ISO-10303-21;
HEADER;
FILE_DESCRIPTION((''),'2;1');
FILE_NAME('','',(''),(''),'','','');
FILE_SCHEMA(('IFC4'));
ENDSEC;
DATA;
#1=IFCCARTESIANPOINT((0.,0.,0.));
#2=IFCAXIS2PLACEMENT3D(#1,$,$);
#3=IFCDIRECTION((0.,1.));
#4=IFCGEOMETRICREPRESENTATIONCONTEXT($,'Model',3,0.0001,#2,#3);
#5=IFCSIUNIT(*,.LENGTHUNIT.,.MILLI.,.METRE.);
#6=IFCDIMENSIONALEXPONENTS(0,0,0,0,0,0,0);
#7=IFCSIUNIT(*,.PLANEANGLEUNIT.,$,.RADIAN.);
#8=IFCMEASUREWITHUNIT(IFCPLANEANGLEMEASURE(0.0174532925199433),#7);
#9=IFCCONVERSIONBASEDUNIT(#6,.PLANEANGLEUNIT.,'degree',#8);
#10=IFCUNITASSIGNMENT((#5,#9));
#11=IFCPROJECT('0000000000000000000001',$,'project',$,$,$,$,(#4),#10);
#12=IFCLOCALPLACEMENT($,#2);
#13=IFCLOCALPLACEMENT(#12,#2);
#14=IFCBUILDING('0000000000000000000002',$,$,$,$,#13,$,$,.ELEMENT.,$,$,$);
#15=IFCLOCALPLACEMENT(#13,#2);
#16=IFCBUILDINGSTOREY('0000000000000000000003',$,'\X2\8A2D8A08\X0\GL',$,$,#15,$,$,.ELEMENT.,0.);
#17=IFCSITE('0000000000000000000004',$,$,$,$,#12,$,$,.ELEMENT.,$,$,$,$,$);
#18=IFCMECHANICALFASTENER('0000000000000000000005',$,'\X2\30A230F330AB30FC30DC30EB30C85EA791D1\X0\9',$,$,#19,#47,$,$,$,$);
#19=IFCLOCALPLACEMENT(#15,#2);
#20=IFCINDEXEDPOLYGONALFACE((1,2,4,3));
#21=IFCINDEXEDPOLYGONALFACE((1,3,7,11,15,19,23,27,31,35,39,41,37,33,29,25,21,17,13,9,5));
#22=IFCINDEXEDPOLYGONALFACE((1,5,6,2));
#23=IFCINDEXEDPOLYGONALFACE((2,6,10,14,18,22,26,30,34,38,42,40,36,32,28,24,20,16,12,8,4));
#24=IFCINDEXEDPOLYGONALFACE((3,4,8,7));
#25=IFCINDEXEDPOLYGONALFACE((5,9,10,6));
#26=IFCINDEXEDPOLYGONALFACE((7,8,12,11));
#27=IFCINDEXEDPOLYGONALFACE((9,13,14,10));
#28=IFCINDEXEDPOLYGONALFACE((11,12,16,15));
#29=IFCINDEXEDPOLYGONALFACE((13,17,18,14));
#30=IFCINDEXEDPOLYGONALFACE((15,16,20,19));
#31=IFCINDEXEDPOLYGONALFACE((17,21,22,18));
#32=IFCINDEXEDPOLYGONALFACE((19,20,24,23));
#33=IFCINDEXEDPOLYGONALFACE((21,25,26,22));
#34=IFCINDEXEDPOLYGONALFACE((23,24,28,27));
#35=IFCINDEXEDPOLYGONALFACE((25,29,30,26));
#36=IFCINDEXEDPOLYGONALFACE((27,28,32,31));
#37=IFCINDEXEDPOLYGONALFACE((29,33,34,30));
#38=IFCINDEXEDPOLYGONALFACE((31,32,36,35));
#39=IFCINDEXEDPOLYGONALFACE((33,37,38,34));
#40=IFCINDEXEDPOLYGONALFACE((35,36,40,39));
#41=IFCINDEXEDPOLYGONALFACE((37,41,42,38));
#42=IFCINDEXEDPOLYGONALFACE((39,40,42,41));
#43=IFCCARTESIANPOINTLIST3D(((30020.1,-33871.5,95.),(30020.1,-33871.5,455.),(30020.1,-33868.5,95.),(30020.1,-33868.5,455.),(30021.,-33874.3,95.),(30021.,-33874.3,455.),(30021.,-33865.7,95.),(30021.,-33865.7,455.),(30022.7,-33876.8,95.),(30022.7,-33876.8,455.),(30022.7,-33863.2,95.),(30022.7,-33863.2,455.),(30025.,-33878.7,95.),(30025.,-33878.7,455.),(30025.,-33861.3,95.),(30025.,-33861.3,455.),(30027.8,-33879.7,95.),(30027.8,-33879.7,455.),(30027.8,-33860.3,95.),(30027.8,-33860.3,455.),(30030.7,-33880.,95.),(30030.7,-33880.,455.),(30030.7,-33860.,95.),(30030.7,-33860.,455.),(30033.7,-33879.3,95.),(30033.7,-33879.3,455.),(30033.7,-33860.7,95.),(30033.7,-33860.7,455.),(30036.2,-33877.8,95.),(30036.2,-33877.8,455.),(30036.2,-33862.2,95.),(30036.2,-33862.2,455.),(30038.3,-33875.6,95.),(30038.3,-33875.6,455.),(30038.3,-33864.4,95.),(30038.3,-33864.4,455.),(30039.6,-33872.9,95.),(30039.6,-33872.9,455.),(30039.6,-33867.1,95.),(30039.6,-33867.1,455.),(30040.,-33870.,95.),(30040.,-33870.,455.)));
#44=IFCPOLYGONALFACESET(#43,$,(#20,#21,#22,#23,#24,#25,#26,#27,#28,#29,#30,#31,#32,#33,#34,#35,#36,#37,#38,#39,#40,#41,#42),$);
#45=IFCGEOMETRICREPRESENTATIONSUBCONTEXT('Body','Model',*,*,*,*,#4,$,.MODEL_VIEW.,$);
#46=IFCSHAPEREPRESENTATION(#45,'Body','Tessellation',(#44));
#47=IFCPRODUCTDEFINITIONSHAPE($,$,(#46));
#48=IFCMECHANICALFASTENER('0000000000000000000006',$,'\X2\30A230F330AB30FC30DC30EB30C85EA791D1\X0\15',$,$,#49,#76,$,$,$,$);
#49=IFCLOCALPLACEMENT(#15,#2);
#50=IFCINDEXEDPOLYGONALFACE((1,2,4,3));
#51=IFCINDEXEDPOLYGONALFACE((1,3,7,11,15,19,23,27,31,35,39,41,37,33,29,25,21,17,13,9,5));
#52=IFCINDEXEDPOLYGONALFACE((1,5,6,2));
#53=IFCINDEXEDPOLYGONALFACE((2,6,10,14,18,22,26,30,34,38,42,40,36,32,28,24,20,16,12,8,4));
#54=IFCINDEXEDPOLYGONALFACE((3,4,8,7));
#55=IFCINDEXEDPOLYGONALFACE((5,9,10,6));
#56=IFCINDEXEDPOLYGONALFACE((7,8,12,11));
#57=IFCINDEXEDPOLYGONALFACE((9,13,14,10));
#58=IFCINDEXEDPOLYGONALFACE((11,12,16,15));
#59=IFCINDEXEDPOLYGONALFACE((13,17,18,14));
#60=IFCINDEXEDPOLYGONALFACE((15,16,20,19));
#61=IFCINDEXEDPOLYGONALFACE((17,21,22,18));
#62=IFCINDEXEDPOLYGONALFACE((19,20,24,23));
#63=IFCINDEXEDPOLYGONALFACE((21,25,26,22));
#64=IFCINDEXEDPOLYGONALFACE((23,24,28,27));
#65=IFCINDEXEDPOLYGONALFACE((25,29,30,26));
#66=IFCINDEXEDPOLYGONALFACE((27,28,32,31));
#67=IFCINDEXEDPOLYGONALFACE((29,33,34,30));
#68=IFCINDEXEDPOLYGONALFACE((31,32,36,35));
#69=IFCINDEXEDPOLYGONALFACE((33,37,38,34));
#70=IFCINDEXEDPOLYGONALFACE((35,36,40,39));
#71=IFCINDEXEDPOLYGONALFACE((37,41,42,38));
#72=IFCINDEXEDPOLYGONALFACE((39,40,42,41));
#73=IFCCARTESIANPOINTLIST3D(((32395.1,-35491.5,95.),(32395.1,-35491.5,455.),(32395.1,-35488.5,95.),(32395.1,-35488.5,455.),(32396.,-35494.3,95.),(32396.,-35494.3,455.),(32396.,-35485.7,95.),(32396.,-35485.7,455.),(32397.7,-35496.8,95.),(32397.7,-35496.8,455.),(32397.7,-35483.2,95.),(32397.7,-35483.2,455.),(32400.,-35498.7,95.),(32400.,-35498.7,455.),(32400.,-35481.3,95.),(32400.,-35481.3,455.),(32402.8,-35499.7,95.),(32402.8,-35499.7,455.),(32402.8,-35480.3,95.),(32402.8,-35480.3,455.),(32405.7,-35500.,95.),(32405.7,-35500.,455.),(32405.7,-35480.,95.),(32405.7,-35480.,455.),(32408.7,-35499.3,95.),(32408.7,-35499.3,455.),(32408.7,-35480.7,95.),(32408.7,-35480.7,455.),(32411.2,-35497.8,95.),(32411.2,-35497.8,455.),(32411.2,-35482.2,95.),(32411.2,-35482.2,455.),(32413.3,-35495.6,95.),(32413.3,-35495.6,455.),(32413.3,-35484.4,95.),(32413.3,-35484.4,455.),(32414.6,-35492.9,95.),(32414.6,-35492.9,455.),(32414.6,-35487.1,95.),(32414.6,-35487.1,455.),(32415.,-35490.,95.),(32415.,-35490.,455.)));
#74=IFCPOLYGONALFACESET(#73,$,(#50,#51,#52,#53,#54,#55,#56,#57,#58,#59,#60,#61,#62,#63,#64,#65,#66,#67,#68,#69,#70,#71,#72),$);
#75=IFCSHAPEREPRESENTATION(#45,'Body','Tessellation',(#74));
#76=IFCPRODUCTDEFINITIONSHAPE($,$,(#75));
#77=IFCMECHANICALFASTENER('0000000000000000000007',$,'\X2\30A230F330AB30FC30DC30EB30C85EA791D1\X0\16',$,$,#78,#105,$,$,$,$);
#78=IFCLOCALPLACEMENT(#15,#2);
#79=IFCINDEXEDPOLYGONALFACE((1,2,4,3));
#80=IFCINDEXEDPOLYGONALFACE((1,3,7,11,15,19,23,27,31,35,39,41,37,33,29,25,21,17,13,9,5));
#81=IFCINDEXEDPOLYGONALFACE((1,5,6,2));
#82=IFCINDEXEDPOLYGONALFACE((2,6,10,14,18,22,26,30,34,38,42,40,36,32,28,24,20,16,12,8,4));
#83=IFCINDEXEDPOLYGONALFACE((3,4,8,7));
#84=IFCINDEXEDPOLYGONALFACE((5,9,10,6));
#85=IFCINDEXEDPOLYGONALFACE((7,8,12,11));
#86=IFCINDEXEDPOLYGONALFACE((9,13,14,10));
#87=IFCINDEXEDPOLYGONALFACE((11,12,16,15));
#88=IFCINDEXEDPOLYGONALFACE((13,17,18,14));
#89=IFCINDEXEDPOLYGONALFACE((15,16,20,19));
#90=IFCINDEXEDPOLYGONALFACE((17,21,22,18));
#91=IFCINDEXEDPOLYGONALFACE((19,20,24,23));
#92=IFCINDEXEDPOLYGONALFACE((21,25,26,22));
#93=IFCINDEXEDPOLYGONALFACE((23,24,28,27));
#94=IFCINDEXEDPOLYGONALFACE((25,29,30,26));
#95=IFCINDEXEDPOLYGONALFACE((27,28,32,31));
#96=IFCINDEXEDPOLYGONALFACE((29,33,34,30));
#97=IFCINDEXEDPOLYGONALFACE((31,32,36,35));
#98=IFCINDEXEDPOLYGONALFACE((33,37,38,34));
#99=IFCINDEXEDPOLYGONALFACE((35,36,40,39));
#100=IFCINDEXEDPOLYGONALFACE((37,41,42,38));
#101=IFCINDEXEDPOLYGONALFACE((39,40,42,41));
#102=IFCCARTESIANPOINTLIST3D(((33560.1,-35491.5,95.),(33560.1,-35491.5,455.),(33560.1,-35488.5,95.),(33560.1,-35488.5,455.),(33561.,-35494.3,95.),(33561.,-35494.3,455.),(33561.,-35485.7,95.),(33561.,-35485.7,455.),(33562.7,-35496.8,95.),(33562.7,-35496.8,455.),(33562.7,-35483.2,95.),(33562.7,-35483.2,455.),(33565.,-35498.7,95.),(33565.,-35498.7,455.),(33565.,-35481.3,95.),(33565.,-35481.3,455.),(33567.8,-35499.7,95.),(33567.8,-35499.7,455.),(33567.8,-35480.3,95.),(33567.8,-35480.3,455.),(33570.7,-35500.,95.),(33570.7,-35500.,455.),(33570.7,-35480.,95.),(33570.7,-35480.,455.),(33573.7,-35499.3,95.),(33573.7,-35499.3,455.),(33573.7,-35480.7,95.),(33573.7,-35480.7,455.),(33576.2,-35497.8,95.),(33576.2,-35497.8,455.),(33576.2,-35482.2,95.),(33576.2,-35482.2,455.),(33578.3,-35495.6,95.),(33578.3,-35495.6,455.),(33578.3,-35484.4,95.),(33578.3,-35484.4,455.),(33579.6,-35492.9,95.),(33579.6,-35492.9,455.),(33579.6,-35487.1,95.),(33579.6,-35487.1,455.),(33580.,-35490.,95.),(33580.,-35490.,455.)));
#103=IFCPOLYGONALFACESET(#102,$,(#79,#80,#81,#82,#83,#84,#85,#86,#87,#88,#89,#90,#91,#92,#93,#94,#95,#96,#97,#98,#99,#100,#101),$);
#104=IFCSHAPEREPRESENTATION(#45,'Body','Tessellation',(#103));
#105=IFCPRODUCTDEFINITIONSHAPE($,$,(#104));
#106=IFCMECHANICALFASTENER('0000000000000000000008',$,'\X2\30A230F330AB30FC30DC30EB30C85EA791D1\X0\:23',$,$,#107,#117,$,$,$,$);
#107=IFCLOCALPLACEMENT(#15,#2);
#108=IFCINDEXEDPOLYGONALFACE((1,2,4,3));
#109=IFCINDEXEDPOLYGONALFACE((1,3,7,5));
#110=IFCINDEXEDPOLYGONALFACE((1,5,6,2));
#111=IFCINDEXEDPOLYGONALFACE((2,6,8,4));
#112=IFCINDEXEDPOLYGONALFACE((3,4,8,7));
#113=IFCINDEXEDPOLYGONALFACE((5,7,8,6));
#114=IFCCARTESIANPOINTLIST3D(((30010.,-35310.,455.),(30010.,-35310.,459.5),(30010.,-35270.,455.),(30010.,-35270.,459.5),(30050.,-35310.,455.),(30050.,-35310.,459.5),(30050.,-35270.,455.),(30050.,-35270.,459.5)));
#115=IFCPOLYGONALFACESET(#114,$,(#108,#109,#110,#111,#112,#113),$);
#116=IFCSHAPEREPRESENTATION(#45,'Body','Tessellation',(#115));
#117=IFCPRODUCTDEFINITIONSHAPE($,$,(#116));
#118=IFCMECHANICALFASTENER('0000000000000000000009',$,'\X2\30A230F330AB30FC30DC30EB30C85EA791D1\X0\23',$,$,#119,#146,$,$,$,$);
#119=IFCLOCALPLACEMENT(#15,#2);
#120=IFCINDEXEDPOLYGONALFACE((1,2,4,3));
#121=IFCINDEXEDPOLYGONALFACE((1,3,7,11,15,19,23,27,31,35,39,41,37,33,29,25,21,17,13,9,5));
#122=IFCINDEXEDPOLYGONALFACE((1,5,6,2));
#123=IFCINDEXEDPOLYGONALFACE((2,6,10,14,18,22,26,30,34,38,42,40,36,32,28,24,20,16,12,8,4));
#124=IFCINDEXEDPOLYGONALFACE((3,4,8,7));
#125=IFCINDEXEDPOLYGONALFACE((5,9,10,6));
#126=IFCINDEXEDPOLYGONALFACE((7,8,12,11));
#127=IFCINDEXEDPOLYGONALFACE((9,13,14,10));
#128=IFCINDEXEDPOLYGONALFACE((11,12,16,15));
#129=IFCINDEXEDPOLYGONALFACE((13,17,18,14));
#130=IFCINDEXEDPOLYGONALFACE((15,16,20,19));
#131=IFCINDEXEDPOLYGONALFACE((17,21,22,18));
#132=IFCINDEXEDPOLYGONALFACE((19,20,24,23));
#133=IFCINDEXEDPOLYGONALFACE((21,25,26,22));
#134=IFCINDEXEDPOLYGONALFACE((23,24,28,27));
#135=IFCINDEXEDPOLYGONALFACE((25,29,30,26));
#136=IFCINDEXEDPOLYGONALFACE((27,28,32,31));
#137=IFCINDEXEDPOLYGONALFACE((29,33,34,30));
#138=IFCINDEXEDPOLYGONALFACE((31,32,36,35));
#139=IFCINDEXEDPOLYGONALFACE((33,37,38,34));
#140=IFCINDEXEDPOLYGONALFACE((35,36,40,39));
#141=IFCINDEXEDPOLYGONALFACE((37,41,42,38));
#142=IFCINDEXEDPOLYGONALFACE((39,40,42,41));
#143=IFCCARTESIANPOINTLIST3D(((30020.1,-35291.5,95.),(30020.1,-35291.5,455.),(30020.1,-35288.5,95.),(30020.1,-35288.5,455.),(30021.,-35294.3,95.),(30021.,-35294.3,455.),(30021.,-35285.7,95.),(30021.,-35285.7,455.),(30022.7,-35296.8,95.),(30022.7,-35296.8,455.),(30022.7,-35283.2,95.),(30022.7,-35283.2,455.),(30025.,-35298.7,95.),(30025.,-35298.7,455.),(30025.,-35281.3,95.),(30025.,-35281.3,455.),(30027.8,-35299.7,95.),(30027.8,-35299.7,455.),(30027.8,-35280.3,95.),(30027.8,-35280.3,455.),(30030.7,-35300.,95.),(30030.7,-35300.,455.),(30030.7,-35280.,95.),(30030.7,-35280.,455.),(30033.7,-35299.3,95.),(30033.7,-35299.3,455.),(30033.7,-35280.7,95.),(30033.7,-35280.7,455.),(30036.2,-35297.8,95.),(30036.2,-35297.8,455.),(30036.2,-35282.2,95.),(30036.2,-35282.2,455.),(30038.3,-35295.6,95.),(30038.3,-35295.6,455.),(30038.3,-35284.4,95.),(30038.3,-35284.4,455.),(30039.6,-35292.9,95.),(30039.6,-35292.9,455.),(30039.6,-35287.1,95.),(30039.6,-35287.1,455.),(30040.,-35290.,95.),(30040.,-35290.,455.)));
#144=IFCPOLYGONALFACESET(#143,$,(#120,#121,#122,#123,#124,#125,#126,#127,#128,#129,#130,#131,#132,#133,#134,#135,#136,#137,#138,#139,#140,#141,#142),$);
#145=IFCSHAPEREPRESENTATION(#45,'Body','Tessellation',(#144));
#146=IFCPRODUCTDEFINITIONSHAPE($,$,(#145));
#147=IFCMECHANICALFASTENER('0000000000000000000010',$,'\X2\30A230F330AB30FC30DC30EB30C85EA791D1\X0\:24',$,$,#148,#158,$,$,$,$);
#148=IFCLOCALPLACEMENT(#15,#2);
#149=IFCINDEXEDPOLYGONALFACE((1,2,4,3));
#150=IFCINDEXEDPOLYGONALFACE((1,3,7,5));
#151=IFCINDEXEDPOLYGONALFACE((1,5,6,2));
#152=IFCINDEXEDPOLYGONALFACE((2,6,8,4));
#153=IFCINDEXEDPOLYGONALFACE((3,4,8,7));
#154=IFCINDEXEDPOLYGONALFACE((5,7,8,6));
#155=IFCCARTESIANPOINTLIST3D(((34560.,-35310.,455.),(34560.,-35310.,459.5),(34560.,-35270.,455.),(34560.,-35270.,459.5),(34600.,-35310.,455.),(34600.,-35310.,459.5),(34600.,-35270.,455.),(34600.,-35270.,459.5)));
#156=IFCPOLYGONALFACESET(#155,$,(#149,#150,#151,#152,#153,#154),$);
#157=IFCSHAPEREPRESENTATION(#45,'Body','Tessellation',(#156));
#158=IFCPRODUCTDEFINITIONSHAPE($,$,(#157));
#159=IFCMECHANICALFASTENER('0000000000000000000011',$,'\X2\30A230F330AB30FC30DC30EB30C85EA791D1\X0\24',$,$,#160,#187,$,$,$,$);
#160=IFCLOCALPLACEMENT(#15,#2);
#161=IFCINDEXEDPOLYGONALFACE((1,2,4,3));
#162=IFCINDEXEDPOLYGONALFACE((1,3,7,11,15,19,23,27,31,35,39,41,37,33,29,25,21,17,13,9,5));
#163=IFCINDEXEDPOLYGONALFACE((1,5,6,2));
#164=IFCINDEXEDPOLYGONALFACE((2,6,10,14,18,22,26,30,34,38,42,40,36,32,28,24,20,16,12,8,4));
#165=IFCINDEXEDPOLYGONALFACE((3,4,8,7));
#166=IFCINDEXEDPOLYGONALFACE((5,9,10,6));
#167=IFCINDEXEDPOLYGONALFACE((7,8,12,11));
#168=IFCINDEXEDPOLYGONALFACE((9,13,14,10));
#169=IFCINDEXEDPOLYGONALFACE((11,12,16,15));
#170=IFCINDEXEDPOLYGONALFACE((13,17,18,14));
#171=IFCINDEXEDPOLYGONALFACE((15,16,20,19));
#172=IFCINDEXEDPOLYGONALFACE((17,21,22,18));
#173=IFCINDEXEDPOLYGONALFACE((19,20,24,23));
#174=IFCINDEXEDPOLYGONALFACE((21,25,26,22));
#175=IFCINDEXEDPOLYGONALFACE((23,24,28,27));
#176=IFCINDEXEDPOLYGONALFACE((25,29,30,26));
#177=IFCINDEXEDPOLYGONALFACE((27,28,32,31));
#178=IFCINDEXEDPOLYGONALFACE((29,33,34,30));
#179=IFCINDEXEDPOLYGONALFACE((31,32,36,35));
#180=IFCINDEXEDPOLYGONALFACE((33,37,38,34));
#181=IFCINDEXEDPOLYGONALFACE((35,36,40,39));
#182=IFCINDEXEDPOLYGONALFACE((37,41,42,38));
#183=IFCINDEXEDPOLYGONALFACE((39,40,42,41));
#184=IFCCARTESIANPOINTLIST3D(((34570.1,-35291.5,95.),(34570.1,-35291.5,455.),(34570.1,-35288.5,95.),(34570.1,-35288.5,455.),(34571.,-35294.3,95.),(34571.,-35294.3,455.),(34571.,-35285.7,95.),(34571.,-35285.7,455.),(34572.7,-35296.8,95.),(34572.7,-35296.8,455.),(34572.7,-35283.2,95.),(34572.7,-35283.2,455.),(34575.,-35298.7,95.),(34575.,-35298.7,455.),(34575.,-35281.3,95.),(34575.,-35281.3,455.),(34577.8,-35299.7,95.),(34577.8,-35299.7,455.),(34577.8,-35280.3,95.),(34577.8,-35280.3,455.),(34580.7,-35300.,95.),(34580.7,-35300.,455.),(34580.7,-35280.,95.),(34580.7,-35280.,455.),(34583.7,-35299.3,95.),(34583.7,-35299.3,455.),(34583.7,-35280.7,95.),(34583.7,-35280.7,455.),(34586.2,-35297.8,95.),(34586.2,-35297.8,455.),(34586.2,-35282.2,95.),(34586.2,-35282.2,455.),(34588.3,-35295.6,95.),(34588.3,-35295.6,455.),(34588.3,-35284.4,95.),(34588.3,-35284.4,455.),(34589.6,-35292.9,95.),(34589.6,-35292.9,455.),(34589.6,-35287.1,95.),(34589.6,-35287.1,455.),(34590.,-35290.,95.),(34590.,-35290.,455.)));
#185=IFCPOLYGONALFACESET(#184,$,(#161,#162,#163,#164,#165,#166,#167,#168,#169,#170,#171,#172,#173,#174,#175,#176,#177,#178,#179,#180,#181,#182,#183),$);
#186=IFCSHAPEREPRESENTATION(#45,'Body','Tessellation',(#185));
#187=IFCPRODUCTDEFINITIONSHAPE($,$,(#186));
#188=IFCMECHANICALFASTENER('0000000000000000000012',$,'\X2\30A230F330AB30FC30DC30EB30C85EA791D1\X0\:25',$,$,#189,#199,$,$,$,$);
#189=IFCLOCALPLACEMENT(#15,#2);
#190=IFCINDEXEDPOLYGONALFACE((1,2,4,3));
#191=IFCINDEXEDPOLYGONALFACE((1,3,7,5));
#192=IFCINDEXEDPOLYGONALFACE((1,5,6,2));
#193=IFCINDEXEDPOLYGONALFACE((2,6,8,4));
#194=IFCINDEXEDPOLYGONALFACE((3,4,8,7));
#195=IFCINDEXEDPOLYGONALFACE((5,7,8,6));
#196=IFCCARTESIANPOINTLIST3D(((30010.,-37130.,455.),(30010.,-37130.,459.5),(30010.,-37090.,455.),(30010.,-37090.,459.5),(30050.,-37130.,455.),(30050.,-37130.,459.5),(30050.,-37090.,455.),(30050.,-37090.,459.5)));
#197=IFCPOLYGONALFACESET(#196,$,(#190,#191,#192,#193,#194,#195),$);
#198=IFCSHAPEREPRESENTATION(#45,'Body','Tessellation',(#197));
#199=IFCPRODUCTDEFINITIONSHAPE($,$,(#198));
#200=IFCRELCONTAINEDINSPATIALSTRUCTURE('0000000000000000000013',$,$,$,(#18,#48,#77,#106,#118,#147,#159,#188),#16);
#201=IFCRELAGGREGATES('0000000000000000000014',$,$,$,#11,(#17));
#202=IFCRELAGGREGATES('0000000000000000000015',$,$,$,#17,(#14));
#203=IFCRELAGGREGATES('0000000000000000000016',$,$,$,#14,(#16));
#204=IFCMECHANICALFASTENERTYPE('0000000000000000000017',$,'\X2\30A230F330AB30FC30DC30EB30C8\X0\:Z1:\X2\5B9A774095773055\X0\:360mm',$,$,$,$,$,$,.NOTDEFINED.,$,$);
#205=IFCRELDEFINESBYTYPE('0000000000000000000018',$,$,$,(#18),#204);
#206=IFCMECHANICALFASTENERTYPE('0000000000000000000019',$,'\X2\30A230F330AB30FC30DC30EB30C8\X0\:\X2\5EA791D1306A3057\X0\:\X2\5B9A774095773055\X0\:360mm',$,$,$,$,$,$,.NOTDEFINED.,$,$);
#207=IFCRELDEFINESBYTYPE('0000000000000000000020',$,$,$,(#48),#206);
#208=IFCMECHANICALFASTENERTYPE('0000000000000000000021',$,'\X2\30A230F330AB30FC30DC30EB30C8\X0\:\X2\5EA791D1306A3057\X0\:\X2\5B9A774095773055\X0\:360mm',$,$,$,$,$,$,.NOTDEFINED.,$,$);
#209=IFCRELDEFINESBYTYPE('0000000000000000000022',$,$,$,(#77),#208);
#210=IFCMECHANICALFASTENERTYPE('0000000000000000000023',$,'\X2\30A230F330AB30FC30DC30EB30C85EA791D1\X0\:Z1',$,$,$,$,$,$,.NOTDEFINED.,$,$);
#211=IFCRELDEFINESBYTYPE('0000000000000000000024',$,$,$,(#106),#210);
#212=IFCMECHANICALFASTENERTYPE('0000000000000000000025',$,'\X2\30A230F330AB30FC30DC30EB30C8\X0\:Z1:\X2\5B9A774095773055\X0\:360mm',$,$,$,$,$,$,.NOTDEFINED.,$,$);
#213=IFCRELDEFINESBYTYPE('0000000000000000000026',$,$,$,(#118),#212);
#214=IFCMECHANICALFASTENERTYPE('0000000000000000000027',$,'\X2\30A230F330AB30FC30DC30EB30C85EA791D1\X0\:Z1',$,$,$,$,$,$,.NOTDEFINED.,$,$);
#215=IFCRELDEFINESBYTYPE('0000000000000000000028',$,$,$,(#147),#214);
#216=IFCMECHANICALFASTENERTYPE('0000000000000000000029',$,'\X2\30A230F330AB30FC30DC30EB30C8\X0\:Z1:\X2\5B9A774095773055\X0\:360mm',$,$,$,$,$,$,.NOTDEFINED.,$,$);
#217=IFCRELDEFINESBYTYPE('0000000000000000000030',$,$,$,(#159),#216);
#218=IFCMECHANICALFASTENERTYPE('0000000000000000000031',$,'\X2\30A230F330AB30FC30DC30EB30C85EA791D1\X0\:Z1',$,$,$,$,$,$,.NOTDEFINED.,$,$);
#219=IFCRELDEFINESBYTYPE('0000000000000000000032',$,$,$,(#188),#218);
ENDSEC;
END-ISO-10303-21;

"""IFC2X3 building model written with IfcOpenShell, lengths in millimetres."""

from ifc_helpers import new_model, entity, si_unit, converted_unit, direction, frame, origin, origin_with_axes, origin_2d, place, context, subcontext, project, spatial, rectangle, circle, extrude, type_object, element, save


model = new_model("IFC2X3")

# Units and contexts
model_context = context("Model", 3, precision=0.0001, world=origin(), true_north=direction((0.0, 1.0)))
body_context = subcontext(model_context, "Body", "Model", "MODEL_VIEW")
ifc_project = project(units=[si_unit("LENGTHUNIT", "METRE", prefix="MILLI"), converted_unit("PLANEANGLEUNIT", "degree", entity("IfcPlaneAngleMeasure", 0.0174532925199433), si_unit("PLANEANGLEUNIT", "RADIAN"), dimensions=[0, 0, 0, 0, 0, 0, 0])], contexts=[model_context])

# Site, building, storey
site_placement = place(None, origin())
site = spatial("IfcSite", under=ifc_project, at=site_placement, CompositionType="ELEMENT")
building_placement = place(site_placement, origin())
building = spatial("IfcBuilding", under=site, at=building_placement, CompositionType="ELEMENT")
storey_placement = place(building_placement, origin())
storey = spatial("IfcBuildingStorey", under=building, at=storey_placement, Name="設計GL", CompositionType="ELEMENT", Elevation=0.0)

# Mechanical fasteners
mechanical_fastener_type_1 = type_object("IfcMechanicalFastenerType", Name="アンカーボルト:Z1:定着長さ:360mm")
mechanical_fastener_1_placement = place(storey_placement, frame((30030.0, -33870.0, 95.0)))
element("IfcMechanicalFastener", 1, at=mechanical_fastener_1_placement, inside=storey, type_object=mechanical_fastener_type_1, Name="アンカーボルト座金9", context=body_context, shape_type="SweptSolid", body=[
    extrude(circle(Radius=10.0, at=origin_2d()), origin_with_axes(), (0.0, 0.0, 1.0), 360.0),
])
mechanical_fastener_type_2 = type_object("IfcMechanicalFastenerType", Name="アンカーボルト:座金なし:定着長さ:360mm")
mechanical_fastener_2_placement = place(storey_placement, frame((32405.0, -35490.0, 95.0)))
element("IfcMechanicalFastener", 2, at=mechanical_fastener_2_placement, inside=storey, type_object=mechanical_fastener_type_2, Name="アンカーボルト座金15", context=body_context, shape_type="SweptSolid", body=[
    extrude(circle(Radius=10.0, at=origin_2d()), origin_with_axes(), (0.0, 0.0, 1.0), 360.0),
])
mechanical_fastener_type_3 = type_object("IfcMechanicalFastenerType", Name="アンカーボルト:座金なし:定着長さ:360mm")
mechanical_fastener_3_placement = place(storey_placement, frame((33570.0, -35490.0, 95.0)))
element("IfcMechanicalFastener", 3, at=mechanical_fastener_3_placement, inside=storey, type_object=mechanical_fastener_type_3, Name="アンカーボルト座金16", context=body_context, shape_type="SweptSolid", body=[
    extrude(circle(Radius=10.0, at=origin_2d()), origin_with_axes(), (0.0, 0.0, 1.0), 360.0),
])
mechanical_fastener_type_4 = type_object("IfcMechanicalFastenerType", Name="アンカーボルト座金:Z1")
mechanical_fastener_4_placement = place(storey_placement, frame((30030.0, -35290.0, 455.0)))
element("IfcMechanicalFastener", 4, at=mechanical_fastener_4_placement, inside=storey, type_object=mechanical_fastener_type_4, Name="アンカーボルト座金:23", context=body_context, shape_type="SweptSolid", body=[
    extrude(rectangle(XDim=40.0, YDim=40.0, at=origin_2d()), origin_with_axes(), (0.0, 0.0, 1.0), 4.5),
])
mechanical_fastener_type_5 = type_object("IfcMechanicalFastenerType", Name="アンカーボルト:Z1:定着長さ:360mm")
mechanical_fastener_5_placement = place(storey_placement, frame((30030.0, -35290.0, 95.0)))
element("IfcMechanicalFastener", 5, at=mechanical_fastener_5_placement, inside=storey, type_object=mechanical_fastener_type_5, Name="アンカーボルト座金23", context=body_context, shape_type="SweptSolid", body=[
    extrude(circle(Radius=10.0, at=origin_2d()), origin_with_axes(), (0.0, 0.0, 1.0), 360.0),
])
mechanical_fastener_type_6 = type_object("IfcMechanicalFastenerType", Name="アンカーボルト座金:Z1")
mechanical_fastener_6_placement = place(storey_placement, frame((34580.0, -35290.0, 455.0)))
element("IfcMechanicalFastener", 6, at=mechanical_fastener_6_placement, inside=storey, type_object=mechanical_fastener_type_6, Name="アンカーボルト座金:24", context=body_context, shape_type="SweptSolid", body=[
    extrude(rectangle(XDim=40.0, YDim=40.0, at=origin_2d()), origin_with_axes(), (0.0, 0.0, 1.0), 4.5),
])
mechanical_fastener_type_7 = type_object("IfcMechanicalFastenerType", Name="アンカーボルト:Z1:定着長さ:360mm")
mechanical_fastener_7_placement = place(storey_placement, frame((34580.0, -35290.0, 95.0)))
element("IfcMechanicalFastener", 7, at=mechanical_fastener_7_placement, inside=storey, type_object=mechanical_fastener_type_7, Name="アンカーボルト座金24", context=body_context, shape_type="SweptSolid", body=[
    extrude(circle(Radius=10.0, at=origin_2d()), origin_with_axes(), (0.0, 0.0, 1.0), 360.0),
])
mechanical_fastener_type_8 = type_object("IfcMechanicalFastenerType", Name="アンカーボルト座金:Z1")
mechanical_fastener_8_placement = place(storey_placement, frame((30030.0, -37110.0, 455.0)))
element("IfcMechanicalFastener", 8, at=mechanical_fastener_8_placement, inside=storey, type_object=mechanical_fastener_type_8, Name="アンカーボルト座金:25", context=body_context, shape_type="SweptSolid", body=[
    extrude(rectangle(XDim=40.0, YDim=40.0, at=origin_2d()), origin_with_axes(), (0.0, 0.0, 1.0), 4.5),
])

save(model, "model.ifc")
